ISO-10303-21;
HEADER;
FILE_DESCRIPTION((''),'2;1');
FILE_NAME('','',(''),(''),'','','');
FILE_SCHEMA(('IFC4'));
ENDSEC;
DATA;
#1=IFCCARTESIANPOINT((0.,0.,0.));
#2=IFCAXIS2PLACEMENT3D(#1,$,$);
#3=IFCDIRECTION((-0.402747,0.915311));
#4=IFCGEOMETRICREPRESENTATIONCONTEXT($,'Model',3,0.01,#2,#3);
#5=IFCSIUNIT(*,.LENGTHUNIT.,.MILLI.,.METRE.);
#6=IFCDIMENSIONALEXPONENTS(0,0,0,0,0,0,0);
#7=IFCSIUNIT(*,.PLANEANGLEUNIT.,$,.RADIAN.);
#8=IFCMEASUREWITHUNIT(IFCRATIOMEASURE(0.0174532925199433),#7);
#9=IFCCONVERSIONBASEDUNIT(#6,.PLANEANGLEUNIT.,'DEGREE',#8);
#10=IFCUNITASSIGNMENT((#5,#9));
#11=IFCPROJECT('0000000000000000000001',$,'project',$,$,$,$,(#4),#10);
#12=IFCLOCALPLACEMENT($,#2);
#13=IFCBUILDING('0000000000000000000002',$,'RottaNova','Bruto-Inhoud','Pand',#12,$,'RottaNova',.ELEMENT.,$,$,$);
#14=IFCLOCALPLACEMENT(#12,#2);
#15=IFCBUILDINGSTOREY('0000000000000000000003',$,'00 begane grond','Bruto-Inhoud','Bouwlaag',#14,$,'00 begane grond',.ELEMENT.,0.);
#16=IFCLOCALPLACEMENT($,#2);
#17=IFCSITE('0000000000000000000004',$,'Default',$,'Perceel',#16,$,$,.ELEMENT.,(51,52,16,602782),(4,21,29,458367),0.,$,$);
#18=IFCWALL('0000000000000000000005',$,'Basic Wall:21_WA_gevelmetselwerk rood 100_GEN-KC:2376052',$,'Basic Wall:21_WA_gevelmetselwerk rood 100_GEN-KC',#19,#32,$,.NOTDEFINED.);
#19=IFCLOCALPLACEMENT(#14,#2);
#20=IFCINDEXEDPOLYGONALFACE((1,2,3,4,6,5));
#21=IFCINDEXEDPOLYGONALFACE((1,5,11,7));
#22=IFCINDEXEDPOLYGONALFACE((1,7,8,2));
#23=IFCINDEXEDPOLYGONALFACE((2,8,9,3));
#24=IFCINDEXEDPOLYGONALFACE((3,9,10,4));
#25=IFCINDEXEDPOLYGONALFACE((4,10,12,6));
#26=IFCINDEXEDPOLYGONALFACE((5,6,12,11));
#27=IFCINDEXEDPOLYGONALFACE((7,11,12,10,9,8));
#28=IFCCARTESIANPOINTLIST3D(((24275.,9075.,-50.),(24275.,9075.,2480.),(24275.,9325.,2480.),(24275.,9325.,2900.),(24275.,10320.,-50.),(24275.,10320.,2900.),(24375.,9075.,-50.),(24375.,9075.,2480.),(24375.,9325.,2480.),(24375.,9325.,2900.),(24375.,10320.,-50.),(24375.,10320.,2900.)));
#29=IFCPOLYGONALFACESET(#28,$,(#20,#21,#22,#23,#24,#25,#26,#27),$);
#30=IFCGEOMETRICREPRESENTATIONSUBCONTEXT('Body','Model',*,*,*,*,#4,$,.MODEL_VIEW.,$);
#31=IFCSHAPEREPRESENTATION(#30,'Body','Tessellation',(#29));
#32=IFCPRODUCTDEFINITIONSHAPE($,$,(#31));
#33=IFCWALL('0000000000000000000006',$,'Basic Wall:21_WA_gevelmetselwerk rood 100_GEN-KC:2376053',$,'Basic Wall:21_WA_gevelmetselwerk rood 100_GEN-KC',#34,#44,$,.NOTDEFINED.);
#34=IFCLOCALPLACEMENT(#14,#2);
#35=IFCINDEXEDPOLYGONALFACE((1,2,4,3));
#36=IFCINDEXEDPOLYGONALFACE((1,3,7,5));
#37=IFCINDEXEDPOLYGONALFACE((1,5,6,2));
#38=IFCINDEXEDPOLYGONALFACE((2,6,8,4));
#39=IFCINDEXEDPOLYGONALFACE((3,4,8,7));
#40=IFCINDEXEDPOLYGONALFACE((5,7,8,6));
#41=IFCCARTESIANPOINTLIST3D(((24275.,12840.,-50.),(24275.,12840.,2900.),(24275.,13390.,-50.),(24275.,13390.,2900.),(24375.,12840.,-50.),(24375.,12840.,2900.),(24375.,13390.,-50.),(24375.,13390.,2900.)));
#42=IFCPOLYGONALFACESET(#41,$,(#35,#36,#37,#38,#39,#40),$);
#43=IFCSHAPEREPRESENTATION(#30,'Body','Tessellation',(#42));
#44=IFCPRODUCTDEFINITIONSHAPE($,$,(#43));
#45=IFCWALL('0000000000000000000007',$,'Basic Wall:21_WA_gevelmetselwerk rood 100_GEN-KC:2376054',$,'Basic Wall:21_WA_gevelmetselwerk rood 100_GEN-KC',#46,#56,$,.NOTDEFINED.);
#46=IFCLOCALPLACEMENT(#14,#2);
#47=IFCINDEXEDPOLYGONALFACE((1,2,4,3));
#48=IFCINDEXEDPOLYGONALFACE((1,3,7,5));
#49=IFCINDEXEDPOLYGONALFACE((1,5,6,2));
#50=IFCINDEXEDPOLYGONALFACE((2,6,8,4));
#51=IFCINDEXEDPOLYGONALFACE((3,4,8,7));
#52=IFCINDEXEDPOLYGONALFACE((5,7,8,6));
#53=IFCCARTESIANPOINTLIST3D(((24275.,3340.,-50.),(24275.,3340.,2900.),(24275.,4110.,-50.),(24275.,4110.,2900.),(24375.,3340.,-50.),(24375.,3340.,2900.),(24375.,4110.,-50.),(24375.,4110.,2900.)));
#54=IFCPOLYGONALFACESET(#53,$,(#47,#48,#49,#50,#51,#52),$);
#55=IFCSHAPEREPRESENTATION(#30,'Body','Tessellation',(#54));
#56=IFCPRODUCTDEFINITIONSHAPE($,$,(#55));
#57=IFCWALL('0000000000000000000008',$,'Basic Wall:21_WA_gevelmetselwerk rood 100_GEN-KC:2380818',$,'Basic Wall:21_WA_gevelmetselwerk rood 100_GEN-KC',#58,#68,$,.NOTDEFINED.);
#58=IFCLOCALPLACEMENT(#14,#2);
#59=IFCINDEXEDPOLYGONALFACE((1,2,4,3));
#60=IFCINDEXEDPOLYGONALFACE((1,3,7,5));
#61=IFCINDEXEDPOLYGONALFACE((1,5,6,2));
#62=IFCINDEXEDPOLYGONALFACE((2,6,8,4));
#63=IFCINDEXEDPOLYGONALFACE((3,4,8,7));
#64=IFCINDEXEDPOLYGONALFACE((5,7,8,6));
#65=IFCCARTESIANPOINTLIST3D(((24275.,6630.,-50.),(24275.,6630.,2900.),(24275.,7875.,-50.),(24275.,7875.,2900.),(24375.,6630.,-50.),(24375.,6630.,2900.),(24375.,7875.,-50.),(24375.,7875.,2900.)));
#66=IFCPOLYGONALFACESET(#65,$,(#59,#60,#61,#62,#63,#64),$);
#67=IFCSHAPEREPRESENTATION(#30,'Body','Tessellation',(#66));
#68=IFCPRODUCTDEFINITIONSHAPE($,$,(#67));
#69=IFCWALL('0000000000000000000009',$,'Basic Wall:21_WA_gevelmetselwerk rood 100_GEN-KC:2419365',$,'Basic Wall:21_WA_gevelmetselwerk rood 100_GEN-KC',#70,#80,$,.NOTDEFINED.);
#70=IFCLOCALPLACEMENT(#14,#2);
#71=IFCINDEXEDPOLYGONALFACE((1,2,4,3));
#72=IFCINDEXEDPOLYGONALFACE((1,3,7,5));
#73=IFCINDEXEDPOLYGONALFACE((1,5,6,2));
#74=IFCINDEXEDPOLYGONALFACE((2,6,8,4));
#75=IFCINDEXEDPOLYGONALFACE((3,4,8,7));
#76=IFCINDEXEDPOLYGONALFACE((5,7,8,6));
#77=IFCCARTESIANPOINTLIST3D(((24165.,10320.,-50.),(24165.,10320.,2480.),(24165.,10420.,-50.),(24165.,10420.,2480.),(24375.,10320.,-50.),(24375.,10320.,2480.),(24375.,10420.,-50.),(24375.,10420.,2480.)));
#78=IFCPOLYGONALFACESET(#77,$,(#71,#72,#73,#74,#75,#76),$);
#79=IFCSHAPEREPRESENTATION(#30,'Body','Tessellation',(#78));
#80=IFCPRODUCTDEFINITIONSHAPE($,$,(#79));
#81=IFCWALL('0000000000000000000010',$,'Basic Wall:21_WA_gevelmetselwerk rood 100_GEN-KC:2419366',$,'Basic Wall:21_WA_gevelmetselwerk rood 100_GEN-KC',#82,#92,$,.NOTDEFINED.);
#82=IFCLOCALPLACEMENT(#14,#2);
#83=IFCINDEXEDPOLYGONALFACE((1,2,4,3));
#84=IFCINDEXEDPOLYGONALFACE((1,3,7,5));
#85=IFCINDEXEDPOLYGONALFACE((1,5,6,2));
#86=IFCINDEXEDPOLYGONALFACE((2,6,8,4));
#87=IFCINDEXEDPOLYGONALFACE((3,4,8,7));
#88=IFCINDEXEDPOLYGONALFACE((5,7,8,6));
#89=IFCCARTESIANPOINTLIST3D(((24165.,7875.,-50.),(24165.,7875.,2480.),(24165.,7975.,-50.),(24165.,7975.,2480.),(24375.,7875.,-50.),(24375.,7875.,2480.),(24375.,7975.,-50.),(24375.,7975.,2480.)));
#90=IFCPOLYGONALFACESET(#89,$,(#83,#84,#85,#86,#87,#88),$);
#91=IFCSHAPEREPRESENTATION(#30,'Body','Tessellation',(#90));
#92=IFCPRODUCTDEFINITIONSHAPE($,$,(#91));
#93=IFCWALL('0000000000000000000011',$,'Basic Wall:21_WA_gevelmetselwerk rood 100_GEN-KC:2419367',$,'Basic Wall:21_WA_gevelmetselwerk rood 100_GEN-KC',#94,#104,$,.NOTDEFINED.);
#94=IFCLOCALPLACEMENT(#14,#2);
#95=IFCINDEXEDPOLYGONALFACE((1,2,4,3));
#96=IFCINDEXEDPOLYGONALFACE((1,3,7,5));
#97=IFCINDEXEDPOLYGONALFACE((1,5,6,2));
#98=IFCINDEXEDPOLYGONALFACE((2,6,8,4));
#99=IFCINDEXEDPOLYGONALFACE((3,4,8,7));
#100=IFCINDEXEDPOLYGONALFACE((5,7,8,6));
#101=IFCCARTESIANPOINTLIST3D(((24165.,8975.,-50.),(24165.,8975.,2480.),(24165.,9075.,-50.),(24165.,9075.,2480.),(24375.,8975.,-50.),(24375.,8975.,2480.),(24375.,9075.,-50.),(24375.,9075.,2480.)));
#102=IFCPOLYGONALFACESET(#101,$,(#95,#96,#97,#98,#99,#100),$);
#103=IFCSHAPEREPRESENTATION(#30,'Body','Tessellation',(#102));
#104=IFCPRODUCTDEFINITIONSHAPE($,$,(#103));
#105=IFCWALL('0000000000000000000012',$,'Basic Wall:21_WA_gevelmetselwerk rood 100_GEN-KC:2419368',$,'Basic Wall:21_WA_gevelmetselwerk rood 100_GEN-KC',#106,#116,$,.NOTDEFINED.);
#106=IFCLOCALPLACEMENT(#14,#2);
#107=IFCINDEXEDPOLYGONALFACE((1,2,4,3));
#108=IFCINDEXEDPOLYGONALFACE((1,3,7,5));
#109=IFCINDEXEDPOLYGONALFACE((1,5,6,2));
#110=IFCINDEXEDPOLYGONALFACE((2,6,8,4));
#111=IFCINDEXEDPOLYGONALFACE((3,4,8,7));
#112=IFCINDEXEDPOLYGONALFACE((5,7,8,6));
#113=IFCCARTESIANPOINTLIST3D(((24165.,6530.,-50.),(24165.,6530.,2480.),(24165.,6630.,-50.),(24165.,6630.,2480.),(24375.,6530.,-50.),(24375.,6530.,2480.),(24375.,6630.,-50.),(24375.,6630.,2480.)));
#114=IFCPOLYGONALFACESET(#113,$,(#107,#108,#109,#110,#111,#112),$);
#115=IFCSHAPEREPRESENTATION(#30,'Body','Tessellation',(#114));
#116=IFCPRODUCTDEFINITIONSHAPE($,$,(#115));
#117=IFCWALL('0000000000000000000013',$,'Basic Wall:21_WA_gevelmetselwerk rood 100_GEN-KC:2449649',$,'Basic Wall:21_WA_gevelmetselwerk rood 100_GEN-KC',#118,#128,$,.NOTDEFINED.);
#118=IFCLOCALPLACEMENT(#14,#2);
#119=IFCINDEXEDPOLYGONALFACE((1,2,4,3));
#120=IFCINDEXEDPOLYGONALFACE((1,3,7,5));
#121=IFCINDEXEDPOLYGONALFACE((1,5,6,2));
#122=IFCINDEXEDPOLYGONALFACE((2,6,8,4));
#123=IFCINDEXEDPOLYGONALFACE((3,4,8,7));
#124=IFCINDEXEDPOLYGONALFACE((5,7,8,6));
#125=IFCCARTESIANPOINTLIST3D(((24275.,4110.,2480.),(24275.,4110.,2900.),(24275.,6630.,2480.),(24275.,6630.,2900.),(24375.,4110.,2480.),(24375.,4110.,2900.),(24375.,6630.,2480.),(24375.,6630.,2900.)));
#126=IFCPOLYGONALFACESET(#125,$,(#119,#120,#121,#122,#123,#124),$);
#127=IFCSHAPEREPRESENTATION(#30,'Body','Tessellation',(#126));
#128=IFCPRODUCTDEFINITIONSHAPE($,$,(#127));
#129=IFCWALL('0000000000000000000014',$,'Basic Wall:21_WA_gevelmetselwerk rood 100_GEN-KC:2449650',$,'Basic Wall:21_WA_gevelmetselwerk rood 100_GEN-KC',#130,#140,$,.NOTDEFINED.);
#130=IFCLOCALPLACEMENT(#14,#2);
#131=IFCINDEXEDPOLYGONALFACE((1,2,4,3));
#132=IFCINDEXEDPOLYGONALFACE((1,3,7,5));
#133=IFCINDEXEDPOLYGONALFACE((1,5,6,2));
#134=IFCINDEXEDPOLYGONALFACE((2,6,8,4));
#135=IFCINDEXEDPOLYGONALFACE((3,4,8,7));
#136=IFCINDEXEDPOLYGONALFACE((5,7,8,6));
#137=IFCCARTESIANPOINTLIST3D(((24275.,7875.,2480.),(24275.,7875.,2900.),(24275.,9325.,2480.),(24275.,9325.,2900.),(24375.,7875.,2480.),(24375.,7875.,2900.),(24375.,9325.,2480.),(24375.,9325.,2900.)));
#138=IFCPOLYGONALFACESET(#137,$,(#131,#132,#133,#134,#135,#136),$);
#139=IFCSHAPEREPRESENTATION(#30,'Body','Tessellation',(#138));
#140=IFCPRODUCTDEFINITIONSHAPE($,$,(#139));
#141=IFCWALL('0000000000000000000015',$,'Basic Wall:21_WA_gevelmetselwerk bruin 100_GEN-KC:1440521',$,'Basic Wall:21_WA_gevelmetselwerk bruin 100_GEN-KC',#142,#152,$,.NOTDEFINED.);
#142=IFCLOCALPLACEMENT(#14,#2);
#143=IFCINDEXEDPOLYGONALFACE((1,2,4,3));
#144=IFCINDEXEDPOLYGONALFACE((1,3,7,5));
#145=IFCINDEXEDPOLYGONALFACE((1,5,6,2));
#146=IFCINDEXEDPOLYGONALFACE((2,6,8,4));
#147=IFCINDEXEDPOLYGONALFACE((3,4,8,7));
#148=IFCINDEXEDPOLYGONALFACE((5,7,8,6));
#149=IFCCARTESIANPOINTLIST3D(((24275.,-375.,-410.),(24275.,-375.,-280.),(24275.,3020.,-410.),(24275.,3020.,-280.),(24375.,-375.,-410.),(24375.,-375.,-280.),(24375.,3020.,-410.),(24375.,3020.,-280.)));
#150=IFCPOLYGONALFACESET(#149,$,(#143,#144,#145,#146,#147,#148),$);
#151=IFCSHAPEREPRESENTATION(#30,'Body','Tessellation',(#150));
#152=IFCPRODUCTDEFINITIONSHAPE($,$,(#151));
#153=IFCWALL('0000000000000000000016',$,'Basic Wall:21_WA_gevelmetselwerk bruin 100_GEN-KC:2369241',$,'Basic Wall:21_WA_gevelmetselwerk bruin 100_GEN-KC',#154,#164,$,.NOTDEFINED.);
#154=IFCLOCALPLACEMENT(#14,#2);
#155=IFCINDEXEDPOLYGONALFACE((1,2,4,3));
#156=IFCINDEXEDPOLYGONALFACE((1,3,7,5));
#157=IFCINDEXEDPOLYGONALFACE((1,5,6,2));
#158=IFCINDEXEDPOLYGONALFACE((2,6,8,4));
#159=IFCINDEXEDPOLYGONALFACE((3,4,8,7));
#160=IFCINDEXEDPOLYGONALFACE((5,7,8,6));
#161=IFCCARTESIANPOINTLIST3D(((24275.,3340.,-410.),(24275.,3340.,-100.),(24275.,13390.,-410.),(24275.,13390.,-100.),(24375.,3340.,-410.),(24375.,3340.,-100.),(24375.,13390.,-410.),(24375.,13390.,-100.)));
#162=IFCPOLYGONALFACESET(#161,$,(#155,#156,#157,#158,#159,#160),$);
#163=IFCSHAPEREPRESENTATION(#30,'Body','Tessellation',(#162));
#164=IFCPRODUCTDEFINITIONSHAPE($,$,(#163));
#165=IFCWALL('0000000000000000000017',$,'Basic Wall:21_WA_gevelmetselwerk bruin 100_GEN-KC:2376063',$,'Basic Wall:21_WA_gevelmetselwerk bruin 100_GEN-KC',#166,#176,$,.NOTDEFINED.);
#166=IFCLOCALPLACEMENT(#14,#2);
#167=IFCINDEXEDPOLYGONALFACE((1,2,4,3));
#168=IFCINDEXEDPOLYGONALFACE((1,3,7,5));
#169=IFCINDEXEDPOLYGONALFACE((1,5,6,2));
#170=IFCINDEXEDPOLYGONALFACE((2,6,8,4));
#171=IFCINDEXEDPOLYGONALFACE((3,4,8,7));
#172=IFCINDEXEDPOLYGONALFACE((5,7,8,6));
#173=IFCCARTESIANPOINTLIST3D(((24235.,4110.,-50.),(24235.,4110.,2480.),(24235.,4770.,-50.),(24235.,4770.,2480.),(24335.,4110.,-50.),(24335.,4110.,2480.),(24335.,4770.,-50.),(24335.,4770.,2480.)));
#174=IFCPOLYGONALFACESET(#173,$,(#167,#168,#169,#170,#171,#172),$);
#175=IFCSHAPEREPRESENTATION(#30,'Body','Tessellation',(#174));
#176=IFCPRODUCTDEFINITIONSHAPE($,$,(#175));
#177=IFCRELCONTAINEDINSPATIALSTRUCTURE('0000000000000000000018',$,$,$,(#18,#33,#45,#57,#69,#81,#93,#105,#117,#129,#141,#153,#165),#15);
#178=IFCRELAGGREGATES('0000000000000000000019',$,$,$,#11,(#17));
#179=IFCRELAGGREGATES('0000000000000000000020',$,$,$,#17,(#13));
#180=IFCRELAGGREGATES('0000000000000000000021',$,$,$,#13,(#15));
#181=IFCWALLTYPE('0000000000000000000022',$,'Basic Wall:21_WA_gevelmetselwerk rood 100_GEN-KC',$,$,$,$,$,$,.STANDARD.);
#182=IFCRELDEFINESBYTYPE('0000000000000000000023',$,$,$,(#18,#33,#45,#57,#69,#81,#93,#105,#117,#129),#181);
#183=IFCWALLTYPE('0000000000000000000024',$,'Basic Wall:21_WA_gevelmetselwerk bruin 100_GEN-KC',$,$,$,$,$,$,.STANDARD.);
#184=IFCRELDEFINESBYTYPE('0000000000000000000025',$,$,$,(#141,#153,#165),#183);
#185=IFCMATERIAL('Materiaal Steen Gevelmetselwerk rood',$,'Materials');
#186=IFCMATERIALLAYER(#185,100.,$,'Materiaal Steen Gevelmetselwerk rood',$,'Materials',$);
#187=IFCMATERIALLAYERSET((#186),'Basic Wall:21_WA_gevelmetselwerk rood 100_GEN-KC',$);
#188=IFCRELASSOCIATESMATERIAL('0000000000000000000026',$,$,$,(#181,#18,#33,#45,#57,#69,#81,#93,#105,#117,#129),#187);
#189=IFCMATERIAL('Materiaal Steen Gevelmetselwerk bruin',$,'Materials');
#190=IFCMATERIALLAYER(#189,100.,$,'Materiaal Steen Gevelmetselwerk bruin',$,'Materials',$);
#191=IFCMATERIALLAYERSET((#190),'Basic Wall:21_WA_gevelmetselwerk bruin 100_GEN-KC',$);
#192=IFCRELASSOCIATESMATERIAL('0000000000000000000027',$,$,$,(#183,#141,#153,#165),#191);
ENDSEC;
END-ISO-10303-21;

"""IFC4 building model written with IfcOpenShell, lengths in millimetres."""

from ifc_helpers import new_model, entity, si_unit, converted_unit, direction, frame, frame_2d, origin, place, context, subcontext, project, spatial, polyline, rectangle, extrude, clip, bounded_halfspace, material, layer, layer_set, type_object, element, save


model = new_model("IFC4")

# Units and contexts
model_context = context("Model", 3, precision=0.01, world=origin(), true_north=direction((-0.402747, 0.915311)))
body_context = subcontext(model_context, "Body", "Model", "MODEL_VIEW")
ifc_project = project(units=[si_unit("LENGTHUNIT", "METRE", prefix="MILLI"), converted_unit("PLANEANGLEUNIT", "DEGREE", entity("IfcRatioMeasure", 0.0174532925199433), si_unit("PLANEANGLEUNIT", "RADIAN"), dimensions=[0, 0, 0, 0, 0, 0, 0])], contexts=[model_context])

# Site, building, storey
site_placement = place(None, origin())
site = spatial("IfcSite", under=ifc_project, at=site_placement, Name="Default", ObjectType="Perceel", CompositionType="ELEMENT", RefLatitude=(51, 52, 16, 602782), RefLongitude=(4, 21, 29, 458367), RefElevation=0.0)
building_placement = place(None, origin())
building = spatial("IfcBuilding", under=site, at=building_placement, Name="RottaNova", Description="Bruto-Inhoud", ObjectType="Pand", LongName="RottaNova", CompositionType="ELEMENT")
storey_placement = place(building_placement, origin())
storey = spatial("IfcBuildingStorey", under=building, at=storey_placement, Name="00 begane grond", Description="Bruto-Inhoud", ObjectType="Bouwlaag", LongName="00 begane grond", CompositionType="ELEMENT", Elevation=0.0)

# Walls
ifc_material_1 = material(Name="Materiaal Steen Gevelmetselwerk rood", Category="Materials")
ifc_layer_1 = layer(ifc_material_1, 100.0, Name="Materiaal Steen Gevelmetselwerk rood", Category="Materials")
ifc_layer_set_1 = layer_set([ifc_layer_1], Name="Basic Wall:21_WA_gevelmetselwerk rood 100_GEN-KC")
wall_type_1 = type_object("IfcWallType", Name="Basic Wall:21_WA_gevelmetselwerk rood 100_GEN-KC", PredefinedType="STANDARD", material=ifc_layer_set_1)
wall_1_placement = place(storey_placement, frame((24325.0, 9075.0, -50.0), z_axis=(0.0, 0.0, 1.0), x_axis=(0.0, 1.0, 0.0)))
element("IfcWall", 1, at=wall_1_placement, inside=storey, type_object=wall_type_1, material=ifc_layer_set_1, Name="Basic Wall:21_WA_gevelmetselwerk rood 100_GEN-KC:2376052", ObjectType="Basic Wall:21_WA_gevelmetselwerk rood 100_GEN-KC", PredefinedType="NOTDEFINED", context=body_context, shape_type="Clipping", body=[
    clip(clip(extrude(rectangle(XDim=1245.0, YDim=100.0, at=frame_2d((622.5, 0.0), x_axis=(-1.0, 0.0))), origin(), (0.0, 0.0, 1.0), 2950.0), bounded_halfspace(frame((250.0, -50.0, 2530.0), z_axis=(0.0, 0.0, -1.0), x_axis=(0.0, 1.0, 0.0)), True, frame((250.0, -50.0, 2530.0), z_axis=(0.0, 0.0, -1.0), x_axis=(0.0, 1.0, 0.0)), polyline([(0.0, 0.0), (0.0, -250.0), (100.0, -250.0), (100.0, 0.0), (0.0, 0.0)]))), bounded_halfspace(frame((250.0, 50.0, 2530.0), z_axis=(1.0, 0.0, 0.0), x_axis=(0.0, 1.0, 0.0)), True, frame((250.0, 50.0, 2530.0), z_axis=(1.0, 0.0, 0.0), x_axis=(0.0, 1.0, 0.0)), polyline([(0.0, 0.0), (0.0, 128016.0), (-30480.0, 128016.0), (-30480.0, 0.0), (0.0, 0.0)]))),
])
wall_2_placement = place(storey_placement, frame((24325.0, 12840.0, -50.0), z_axis=(0.0, 0.0, 1.0), x_axis=(0.0, 1.0, 0.0)))
element("IfcWall", 2, at=wall_2_placement, inside=storey, type_object=wall_type_1, material=ifc_layer_set_1, Name="Basic Wall:21_WA_gevelmetselwerk rood 100_GEN-KC:2376053", ObjectType="Basic Wall:21_WA_gevelmetselwerk rood 100_GEN-KC", PredefinedType="NOTDEFINED", context=body_context, shape_type="SweptSolid", body=[
    extrude(rectangle(XDim=550.0, YDim=100.0, at=frame_2d((275.0, 0.0), x_axis=(-1.0, 0.0))), origin(), (0.0, 0.0, 1.0), 2950.0),
])
wall_3_placement = place(storey_placement, frame((24325.0, 3340.0, -50.0), z_axis=(0.0, 0.0, 1.0), x_axis=(0.0, 1.0, 0.0)))
element("IfcWall", 3, at=wall_3_placement, inside=storey, type_object=wall_type_1, material=ifc_layer_set_1, Name="Basic Wall:21_WA_gevelmetselwerk rood 100_GEN-KC:2376054", ObjectType="Basic Wall:21_WA_gevelmetselwerk rood 100_GEN-KC", PredefinedType="NOTDEFINED", context=body_context, shape_type="SweptSolid", body=[
    extrude(rectangle(XDim=770.0, YDim=100.0, at=frame_2d((385.0, 0.0), x_axis=(-1.0, 0.0))), origin(), (0.0, 0.0, 1.0), 2950.0),
])
wall_4_placement = place(storey_placement, frame((24325.0, 6630.0, -50.0), z_axis=(0.0, 0.0, 1.0), x_axis=(0.0, 1.0, 0.0)))
element("IfcWall", 4, at=wall_4_placement, inside=storey, type_object=wall_type_1, material=ifc_layer_set_1, Name="Basic Wall:21_WA_gevelmetselwerk rood 100_GEN-KC:2380818", ObjectType="Basic Wall:21_WA_gevelmetselwerk rood 100_GEN-KC", PredefinedType="NOTDEFINED", context=body_context, shape_type="SweptSolid", body=[
    extrude(rectangle(XDim=1245.0, YDim=100.0, at=frame_2d((622.5, 0.0), x_axis=(-1.0, 0.0))), origin(), (0.0, 0.0, 1.0), 2950.0),
])
wall_5_placement = place(storey_placement, frame((24375.0, 10370.0, -50.0), z_axis=(0.0, 0.0, 1.0), x_axis=(-1.0, 0.0, 0.0)))
element("IfcWall", 5, at=wall_5_placement, inside=storey, type_object=wall_type_1, material=ifc_layer_set_1, Name="Basic Wall:21_WA_gevelmetselwerk rood 100_GEN-KC:2419365", ObjectType="Basic Wall:21_WA_gevelmetselwerk rood 100_GEN-KC", PredefinedType="NOTDEFINED", context=body_context, shape_type="SweptSolid", body=[
    extrude(rectangle(XDim=210.0, YDim=100.0, at=frame_2d((105.0, 0.0), x_axis=(-1.0, 0.0))), origin(), (0.0, 0.0, 1.0), 2530.0),
])
wall_6_placement = place(storey_placement, frame((24375.0, 7925.0, -50.0), z_axis=(0.0, 0.0, 1.0), x_axis=(-1.0, 0.0, 0.0)))
element("IfcWall", 6, at=wall_6_placement, inside=storey, type_object=wall_type_1, material=ifc_layer_set_1, Name="Basic Wall:21_WA_gevelmetselwerk rood 100_GEN-KC:2419366", ObjectType="Basic Wall:21_WA_gevelmetselwerk rood 100_GEN-KC", PredefinedType="NOTDEFINED", context=body_context, shape_type="SweptSolid", body=[
    extrude(rectangle(XDim=210.0, YDim=100.0, at=frame_2d((105.0, 0.0), x_axis=(-1.0, 0.0))), origin(), (0.0, 0.0, 1.0), 2530.0),
])
wall_7_placement = place(storey_placement, frame((24375.0, 9025.0, -50.0), z_axis=(0.0, 0.0, 1.0), x_axis=(-1.0, 0.0, 0.0)))
element("IfcWall", 7, at=wall_7_placement, inside=storey, type_object=wall_type_1, material=ifc_layer_set_1, Name="Basic Wall:21_WA_gevelmetselwerk rood 100_GEN-KC:2419367", ObjectType="Basic Wall:21_WA_gevelmetselwerk rood 100_GEN-KC", PredefinedType="NOTDEFINED", context=body_context, shape_type="SweptSolid", body=[
    extrude(rectangle(XDim=210.0, YDim=100.0, at=frame_2d((105.0, 0.0), x_axis=(-1.0, 0.0))), origin(), (0.0, 0.0, 1.0), 2530.0),
])
wall_8_placement = place(storey_placement, frame((24375.0, 6580.0, -50.0), z_axis=(0.0, 0.0, 1.0), x_axis=(-1.0, 0.0, 0.0)))
element("IfcWall", 8, at=wall_8_placement, inside=storey, type_object=wall_type_1, material=ifc_layer_set_1, Name="Basic Wall:21_WA_gevelmetselwerk rood 100_GEN-KC:2419368", ObjectType="Basic Wall:21_WA_gevelmetselwerk rood 100_GEN-KC", PredefinedType="NOTDEFINED", context=body_context, shape_type="SweptSolid", body=[
    extrude(rectangle(XDim=210.0, YDim=100.0, at=frame_2d((105.0, 0.0), x_axis=(-1.0, 0.0))), origin(), (0.0, 0.0, 1.0), 2530.0),
])
wall_9_placement = place(storey_placement, frame((24325.0, 4110.0, 2480.0), z_axis=(0.0, 0.0, 1.0), x_axis=(0.0, 1.0, 0.0)))
element("IfcWall", 9, at=wall_9_placement, inside=storey, type_object=wall_type_1, material=ifc_layer_set_1, Name="Basic Wall:21_WA_gevelmetselwerk rood 100_GEN-KC:2449649", ObjectType="Basic Wall:21_WA_gevelmetselwerk rood 100_GEN-KC", PredefinedType="NOTDEFINED", context=body_context, shape_type="SweptSolid", body=[
    extrude(rectangle(XDim=2520.0, YDim=100.0, at=frame_2d((1260.0, 0.0), x_axis=(-1.0, 0.0))), origin(), (0.0, 0.0, 1.0), 420.0),
])
wall_10_placement = place(storey_placement, frame((24325.0, 7875.0, 2480.0), z_axis=(0.0, 0.0, 1.0), x_axis=(0.0, 1.0, 0.0)))
element("IfcWall", 10, at=wall_10_placement, inside=storey, type_object=wall_type_1, material=ifc_layer_set_1, Name="Basic Wall:21_WA_gevelmetselwerk rood 100_GEN-KC:2449650", ObjectType="Basic Wall:21_WA_gevelmetselwerk rood 100_GEN-KC", PredefinedType="NOTDEFINED", context=body_context, shape_type="SweptSolid", body=[
    extrude(rectangle(XDim=1450.0, YDim=100.0, at=frame_2d((725.0, 0.0), x_axis=(-1.0, 0.0))), origin(), (0.0, 0.0, 1.0), 420.0),
])
ifc_material_2 = material(Name="Materiaal Steen Gevelmetselwerk bruin", Category="Materials")
ifc_layer_2 = layer(ifc_material_2, 100.0, Name="Materiaal Steen Gevelmetselwerk bruin", Category="Materials")
ifc_layer_set_2 = layer_set([ifc_layer_2], Name="Basic Wall:21_WA_gevelmetselwerk bruin 100_GEN-KC")
wall_type_2 = type_object("IfcWallType", Name="Basic Wall:21_WA_gevelmetselwerk bruin 100_GEN-KC", PredefinedType="STANDARD", material=ifc_layer_set_2)
wall_11_placement = place(storey_placement, frame((24325.0, 3020.0, -410.0), z_axis=(0.0, 0.0, 1.0), x_axis=(0.0, -1.0, 0.0)))
element("IfcWall", 11, at=wall_11_placement, inside=storey, type_object=wall_type_2, material=ifc_layer_set_2, Name="Basic Wall:21_WA_gevelmetselwerk bruin 100_GEN-KC:1440521", ObjectType="Basic Wall:21_WA_gevelmetselwerk bruin 100_GEN-KC", PredefinedType="NOTDEFINED", context=body_context, shape_type="SweptSolid", body=[
    extrude(rectangle(XDim=3395.0, YDim=100.0, at=frame_2d((1697.5, 0.0), x_axis=(-1.0, 0.0))), origin(), (0.0, 0.0, 1.0), 130.0),
])
wall_12_placement = place(storey_placement, frame((24325.0, 3340.0, -410.0), z_axis=(0.0, 0.0, 1.0), x_axis=(0.0, 1.0, 0.0)))
element("IfcWall", 12, at=wall_12_placement, inside=storey, type_object=wall_type_2, material=ifc_layer_set_2, Name="Basic Wall:21_WA_gevelmetselwerk bruin 100_GEN-KC:2369241", ObjectType="Basic Wall:21_WA_gevelmetselwerk bruin 100_GEN-KC", PredefinedType="NOTDEFINED", context=body_context, shape_type="SweptSolid", body=[
    extrude(rectangle(XDim=10050.0, YDim=100.0, at=frame_2d((5025.0, 0.0), x_axis=(-1.0, 0.0))), origin(), (0.0, 0.0, 1.0), 310.0),
])
wall_13_placement = place(storey_placement, frame((24285.0, 4110.0, -50.0), z_axis=(0.0, 0.0, 1.0), x_axis=(0.0, 1.0, 0.0)))
element("IfcWall", 13, at=wall_13_placement, inside=storey, type_object=wall_type_2, material=ifc_layer_set_2, Name="Basic Wall:21_WA_gevelmetselwerk bruin 100_GEN-KC:2376063", ObjectType="Basic Wall:21_WA_gevelmetselwerk bruin 100_GEN-KC", PredefinedType="NOTDEFINED", context=body_context, shape_type="SweptSolid", body=[
    extrude(rectangle(XDim=660.0, YDim=100.0, at=frame_2d((330.0, 0.0), x_axis=(-1.0, 0.0))), origin(), (0.0, 0.0, 1.0), 2530.0),
])

save(model, "model.ifc")
